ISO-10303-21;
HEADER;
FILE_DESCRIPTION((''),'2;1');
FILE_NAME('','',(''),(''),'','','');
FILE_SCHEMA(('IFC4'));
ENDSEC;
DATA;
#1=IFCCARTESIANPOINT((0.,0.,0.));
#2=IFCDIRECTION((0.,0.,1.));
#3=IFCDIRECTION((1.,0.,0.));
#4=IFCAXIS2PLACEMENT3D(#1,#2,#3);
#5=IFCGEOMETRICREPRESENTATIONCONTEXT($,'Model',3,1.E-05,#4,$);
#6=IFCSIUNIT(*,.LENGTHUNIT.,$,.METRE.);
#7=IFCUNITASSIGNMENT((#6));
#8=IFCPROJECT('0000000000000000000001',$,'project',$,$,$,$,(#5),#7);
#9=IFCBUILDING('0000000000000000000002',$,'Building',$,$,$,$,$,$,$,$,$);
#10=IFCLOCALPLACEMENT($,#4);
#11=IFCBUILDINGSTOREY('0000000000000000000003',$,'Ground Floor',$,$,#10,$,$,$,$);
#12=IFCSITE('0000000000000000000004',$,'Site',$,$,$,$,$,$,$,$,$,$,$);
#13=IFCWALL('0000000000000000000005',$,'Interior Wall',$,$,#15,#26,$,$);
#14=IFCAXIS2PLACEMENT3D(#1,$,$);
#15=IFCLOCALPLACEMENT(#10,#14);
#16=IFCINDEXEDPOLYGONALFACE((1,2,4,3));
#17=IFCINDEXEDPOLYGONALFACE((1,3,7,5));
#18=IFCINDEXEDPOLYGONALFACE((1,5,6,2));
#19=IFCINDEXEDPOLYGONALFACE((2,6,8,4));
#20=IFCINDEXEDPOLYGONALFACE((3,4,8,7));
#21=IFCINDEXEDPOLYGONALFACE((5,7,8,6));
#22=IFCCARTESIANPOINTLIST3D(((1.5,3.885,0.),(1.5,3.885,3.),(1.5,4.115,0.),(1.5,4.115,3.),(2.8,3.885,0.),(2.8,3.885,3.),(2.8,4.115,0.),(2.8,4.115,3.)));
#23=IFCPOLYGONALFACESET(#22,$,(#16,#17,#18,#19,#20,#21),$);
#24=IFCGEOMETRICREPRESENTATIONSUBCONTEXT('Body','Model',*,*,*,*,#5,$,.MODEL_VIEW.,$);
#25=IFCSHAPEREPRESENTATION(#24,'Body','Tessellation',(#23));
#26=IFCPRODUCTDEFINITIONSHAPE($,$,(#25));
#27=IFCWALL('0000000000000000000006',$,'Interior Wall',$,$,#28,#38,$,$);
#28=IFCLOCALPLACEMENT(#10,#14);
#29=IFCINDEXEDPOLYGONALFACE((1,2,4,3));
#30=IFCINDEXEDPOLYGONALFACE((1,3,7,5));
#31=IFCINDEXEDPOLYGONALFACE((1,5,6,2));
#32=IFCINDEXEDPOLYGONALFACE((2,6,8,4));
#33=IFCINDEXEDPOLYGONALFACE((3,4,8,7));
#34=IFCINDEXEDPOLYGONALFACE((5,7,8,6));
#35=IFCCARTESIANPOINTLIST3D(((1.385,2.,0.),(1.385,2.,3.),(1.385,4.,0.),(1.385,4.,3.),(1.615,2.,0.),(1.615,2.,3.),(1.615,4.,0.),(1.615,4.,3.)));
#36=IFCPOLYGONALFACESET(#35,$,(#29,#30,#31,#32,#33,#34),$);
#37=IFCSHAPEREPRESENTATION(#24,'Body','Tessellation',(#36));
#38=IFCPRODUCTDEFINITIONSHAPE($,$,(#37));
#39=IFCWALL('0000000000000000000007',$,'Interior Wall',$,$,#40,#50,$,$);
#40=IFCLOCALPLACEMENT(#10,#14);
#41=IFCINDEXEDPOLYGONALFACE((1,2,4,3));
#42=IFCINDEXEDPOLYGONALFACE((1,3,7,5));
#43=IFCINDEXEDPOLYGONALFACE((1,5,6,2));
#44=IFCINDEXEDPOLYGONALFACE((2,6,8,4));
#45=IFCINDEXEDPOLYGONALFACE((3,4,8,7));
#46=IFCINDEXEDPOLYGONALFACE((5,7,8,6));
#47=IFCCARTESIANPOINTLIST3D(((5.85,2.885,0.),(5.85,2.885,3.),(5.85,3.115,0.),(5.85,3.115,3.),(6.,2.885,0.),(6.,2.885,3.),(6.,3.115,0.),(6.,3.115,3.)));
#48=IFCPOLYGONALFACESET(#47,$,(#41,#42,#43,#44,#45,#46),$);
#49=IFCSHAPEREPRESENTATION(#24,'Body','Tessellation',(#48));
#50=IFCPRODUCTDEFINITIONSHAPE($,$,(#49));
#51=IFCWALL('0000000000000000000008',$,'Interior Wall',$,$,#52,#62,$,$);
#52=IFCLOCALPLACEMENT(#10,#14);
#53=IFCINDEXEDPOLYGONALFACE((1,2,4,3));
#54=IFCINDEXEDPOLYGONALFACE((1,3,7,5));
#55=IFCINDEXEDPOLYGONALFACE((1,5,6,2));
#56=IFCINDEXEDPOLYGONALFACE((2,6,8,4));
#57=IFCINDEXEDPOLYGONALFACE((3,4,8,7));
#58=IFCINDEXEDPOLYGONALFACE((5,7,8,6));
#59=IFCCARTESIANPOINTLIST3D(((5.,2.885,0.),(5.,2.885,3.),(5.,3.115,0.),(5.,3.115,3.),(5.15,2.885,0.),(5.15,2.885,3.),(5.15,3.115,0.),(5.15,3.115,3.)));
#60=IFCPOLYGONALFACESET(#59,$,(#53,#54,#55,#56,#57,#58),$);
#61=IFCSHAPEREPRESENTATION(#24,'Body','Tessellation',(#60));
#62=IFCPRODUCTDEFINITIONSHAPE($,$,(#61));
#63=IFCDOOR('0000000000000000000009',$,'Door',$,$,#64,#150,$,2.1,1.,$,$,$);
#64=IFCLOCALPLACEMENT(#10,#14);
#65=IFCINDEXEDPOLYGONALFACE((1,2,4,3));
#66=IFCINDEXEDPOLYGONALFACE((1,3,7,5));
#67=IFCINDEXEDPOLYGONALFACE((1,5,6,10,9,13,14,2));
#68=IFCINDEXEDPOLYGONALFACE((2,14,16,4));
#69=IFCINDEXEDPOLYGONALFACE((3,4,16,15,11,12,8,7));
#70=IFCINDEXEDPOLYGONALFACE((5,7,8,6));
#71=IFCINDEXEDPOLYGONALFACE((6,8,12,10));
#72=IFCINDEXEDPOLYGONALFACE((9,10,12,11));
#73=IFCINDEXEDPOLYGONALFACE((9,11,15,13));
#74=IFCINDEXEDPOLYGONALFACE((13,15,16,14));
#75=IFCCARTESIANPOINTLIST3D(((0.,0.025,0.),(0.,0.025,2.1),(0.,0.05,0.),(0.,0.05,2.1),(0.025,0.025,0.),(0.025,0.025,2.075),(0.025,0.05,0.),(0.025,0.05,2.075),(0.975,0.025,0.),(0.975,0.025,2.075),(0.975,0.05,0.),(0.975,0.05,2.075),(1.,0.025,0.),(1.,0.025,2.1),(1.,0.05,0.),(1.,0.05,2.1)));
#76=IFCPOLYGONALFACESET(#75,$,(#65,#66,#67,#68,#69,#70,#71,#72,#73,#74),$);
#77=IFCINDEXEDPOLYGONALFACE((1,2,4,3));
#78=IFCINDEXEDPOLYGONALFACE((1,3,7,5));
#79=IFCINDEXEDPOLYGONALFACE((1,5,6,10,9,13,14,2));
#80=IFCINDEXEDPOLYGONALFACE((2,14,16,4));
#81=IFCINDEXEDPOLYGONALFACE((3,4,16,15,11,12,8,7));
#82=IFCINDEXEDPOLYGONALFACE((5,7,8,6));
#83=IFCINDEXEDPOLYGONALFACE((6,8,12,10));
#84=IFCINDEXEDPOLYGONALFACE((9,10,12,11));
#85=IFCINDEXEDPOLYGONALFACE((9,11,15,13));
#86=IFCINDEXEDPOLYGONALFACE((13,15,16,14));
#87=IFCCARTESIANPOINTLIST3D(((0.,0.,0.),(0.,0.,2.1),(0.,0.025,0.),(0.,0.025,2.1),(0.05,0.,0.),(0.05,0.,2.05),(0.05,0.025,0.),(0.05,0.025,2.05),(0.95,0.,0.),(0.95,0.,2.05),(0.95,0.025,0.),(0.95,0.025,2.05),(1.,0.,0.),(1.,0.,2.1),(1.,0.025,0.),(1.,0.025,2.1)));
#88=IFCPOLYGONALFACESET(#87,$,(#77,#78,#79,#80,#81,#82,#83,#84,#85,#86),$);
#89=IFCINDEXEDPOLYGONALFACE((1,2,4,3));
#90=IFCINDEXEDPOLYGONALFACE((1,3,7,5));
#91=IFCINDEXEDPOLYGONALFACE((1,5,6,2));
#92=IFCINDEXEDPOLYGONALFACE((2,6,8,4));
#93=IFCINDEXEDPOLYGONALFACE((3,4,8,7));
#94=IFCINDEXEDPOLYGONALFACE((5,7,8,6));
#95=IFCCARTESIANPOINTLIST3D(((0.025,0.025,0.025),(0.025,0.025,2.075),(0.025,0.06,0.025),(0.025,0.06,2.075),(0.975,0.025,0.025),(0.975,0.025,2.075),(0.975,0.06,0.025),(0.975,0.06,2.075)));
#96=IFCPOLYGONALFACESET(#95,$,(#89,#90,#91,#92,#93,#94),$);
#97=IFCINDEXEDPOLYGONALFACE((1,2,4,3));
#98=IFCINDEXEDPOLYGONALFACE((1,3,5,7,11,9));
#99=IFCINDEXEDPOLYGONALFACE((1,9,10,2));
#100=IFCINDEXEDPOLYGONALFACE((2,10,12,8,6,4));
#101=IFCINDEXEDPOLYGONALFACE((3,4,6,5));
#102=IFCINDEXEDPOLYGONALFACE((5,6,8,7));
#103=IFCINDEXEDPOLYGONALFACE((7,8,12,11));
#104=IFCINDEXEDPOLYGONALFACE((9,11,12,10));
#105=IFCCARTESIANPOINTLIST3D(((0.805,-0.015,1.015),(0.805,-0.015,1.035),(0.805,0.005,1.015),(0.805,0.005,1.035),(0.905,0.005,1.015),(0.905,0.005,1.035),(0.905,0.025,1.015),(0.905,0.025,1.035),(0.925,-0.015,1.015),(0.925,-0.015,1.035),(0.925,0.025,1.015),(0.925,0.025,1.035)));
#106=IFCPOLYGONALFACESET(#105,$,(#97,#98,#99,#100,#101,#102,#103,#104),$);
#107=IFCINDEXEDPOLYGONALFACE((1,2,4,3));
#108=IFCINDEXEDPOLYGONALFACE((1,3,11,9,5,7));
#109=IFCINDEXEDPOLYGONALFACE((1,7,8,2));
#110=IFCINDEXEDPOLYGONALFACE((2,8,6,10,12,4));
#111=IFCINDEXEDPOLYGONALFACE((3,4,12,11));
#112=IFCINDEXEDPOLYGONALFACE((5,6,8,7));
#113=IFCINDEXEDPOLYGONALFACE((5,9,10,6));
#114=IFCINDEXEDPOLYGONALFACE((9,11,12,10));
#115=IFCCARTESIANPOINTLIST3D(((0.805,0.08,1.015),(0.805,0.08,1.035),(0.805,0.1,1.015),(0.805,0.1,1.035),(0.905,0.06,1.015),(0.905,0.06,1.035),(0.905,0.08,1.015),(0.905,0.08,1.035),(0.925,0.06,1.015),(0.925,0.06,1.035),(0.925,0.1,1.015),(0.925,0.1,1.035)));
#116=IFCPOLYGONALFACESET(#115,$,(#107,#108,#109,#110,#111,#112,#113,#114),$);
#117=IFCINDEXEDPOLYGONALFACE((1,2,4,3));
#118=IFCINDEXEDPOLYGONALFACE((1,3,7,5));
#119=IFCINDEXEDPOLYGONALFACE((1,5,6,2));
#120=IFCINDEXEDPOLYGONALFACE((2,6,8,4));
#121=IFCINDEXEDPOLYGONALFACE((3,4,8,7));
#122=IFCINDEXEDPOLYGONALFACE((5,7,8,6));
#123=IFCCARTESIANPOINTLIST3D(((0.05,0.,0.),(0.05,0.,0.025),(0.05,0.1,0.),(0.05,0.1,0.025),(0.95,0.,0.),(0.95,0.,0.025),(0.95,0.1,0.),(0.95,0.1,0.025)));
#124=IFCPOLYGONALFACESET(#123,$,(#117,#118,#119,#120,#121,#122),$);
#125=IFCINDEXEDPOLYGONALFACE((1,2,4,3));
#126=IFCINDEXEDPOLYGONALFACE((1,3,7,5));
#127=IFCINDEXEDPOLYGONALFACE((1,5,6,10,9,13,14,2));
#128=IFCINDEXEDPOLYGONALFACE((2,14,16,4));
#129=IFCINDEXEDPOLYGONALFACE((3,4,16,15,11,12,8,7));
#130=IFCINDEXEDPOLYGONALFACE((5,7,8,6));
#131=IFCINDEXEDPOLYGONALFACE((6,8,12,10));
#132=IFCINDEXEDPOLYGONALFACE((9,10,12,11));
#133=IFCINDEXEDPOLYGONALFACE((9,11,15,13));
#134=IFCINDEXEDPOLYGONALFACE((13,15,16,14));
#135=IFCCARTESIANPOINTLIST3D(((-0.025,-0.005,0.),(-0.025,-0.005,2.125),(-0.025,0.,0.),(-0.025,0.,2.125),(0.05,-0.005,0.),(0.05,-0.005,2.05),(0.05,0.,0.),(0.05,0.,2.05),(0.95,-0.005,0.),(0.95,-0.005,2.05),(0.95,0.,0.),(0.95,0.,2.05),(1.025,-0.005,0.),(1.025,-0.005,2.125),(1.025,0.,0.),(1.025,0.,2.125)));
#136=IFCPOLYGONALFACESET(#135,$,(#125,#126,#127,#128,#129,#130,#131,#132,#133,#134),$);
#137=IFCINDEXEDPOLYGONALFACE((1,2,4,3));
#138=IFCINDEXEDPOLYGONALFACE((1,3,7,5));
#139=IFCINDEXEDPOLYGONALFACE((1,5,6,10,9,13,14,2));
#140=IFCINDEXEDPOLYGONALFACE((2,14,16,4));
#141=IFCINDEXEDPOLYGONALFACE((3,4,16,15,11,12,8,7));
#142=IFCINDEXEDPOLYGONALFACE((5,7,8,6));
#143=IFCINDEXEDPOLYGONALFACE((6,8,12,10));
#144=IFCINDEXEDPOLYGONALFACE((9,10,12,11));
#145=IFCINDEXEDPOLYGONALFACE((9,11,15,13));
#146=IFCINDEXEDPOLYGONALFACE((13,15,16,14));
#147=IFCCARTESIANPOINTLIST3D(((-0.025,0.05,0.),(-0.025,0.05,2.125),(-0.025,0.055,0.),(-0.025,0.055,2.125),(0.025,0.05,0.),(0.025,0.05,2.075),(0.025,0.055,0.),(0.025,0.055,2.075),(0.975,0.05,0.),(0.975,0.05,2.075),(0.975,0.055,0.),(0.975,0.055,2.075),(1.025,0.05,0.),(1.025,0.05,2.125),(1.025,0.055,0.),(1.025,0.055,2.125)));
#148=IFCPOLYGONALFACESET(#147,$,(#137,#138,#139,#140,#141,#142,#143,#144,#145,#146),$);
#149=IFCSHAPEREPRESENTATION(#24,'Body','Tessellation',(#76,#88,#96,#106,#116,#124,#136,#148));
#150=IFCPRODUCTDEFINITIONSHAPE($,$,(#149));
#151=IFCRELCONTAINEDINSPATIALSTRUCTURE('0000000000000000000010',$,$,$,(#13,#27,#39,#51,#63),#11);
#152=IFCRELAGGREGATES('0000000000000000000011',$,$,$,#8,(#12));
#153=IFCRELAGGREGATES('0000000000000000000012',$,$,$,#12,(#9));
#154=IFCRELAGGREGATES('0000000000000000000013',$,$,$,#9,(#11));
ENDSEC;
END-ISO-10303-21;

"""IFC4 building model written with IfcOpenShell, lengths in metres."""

from ifc_helpers import new_model, si_unit, frame, origin_with_axes, place, context, subcontext, project, spatial, line, indexed_curve, outline, extrude, element, save


model = new_model("IFC4")

# Units and contexts
model_context = context("Model", 3, precision=1e-05, world=origin_with_axes())
body_context = subcontext(model_context, "Body", "Model", "MODEL_VIEW")
ifc_project = project(units=[si_unit("LENGTHUNIT", "METRE")], contexts=[model_context])

# Site, building, storey
site = spatial("IfcSite", under=ifc_project, Name="Site")
building = spatial("IfcBuilding", under=site, Name="Building")
storey_placement = place(None, origin_with_axes())
storey = spatial("IfcBuildingStorey", under=building, at=storey_placement, Name="Ground Floor")

# Walls
for number, where, z_axis, x_axis, name in (
    (1, (2.8, 4.0, 0.0), (0.0, 0.0, 1.0), (-1.0, 0.0, 0.0), "Interior Wall"),
):
    element("IfcWall", number, at=place(storey_placement, frame(where, z_axis=z_axis, x_axis=x_axis)), inside=storey, Name=name, context=body_context, shape_type="SweptSolid", body=[
        extrude(outline(indexed_curve([(0.0, 0.0), (0.0, 0.23), (1.3, 0.23), (1.3, 0.0), (0.0, 0.0)], self_intersect=False)), frame((0.0, -0.115, 0.0), z_axis=(0.0, 0.0, 1.0), x_axis=(1.0, 0.0, 0.0)), (0.0, 0.0, 1.0), 3.0),
    ])
wall_1_placement = place(storey_placement, frame((1.5, 4.0, 0.0), z_axis=(0.0, 0.0, 1.0), x_axis=(0.0, -1.0, 0.0)))
element("IfcWall", 2, at=wall_1_placement, inside=storey, Name="Interior Wall", context=body_context, shape_type="SweptSolid", body=[
    extrude(outline(indexed_curve([(0.0, 0.0), (0.0, 0.23), (2.0, 0.23), (2.0, 0.0), (0.0, 0.0)], self_intersect=False)), frame((0.0, -0.115, 0.0), z_axis=(0.0, 0.0, 1.0), x_axis=(1.0, 0.0, 0.0)), (0.0, 0.0, 1.0), 3.0),
])
for number, where, z_axis, x_axis, name in (
    (3, (6.0, 3.0, 0.0), (0.0, 0.0, 1.0), (-1.0, 0.0, 0.0), "Interior Wall"),
    (4, (5.15, 3.0, 0.0), (0.0, 0.0, 1.0), (-1.0, 0.0, 0.0), "Interior Wall"),
):
    element("IfcWall", number, at=place(storey_placement, frame(where, z_axis=z_axis, x_axis=x_axis)), inside=storey, Name=name, context=body_context, shape_type="SweptSolid", body=[
        extrude(outline(indexed_curve([(0.0, 0.0), (0.0, 0.23), (0.15, 0.23), (0.15, 0.0), (0.0, 0.0)], self_intersect=False)), frame((0.0, -0.115, 0.0), z_axis=(0.0, 0.0, 1.0), x_axis=(1.0, 0.0, 0.0)), (0.0, 0.0, 1.0), 3.0),
    ])

# Door
door_1_placement = place(storey_placement, origin_with_axes())
element("IfcDoor", 5, at=door_1_placement, inside=storey, Name="Door", OverallHeight=2.1, OverallWidth=1.0, context=body_context, shape_type="SweptSolid", body=[
    extrude(outline(indexed_curve([(0.0, 0.0), (0.0, 2.1), (1.0, 2.1), (1.0, 0.0), (0.975, 0.0), (0.975, 2.075), (0.025, 2.075), (0.025, 0.0)], segments=[line(1, 2, 3, 4, 5, 6, 7, 8, 1)])), frame((0.0, 0.025, 0.0), z_axis=(0.0, -1.0, 0.0), x_axis=(1.0, 0.0, 0.0)), (0.0, 0.0, -1.0), 0.025),
    extrude(outline(indexed_curve([(0.0, 0.0), (0.0, 2.1), (1.0, 2.1), (1.0, 0.0), (0.95, 0.0), (0.95, 2.05), (0.05, 2.05), (0.05, 0.0)], segments=[line(1, 2, 3, 4, 5, 6, 7, 8, 1)])), frame((0.0, 0.0, 0.0), z_axis=(0.0, -1.0, 0.0), x_axis=(1.0, 0.0, 0.0)), (0.0, 0.0, -1.0), 0.025),
    extrude(outline(indexed_curve([(0.0, 0.0), (0.95, 0.0), (0.95, 0.035), (0.0, 0.035)], segments=[line(1, 2, 3, 4, 1)])), frame((0.025, 0.025, 0.025), z_axis=(0.0, 0.0, 1.0), x_axis=(1.0, 0.0, 0.0)), (0.0, 0.0, 1.0), 2.05),
    extrude(outline(indexed_curve([(0.0, 0.0), (0.0, -0.04), (-0.12, -0.04), (-0.12, -0.02), (-0.02, -0.02), (-0.02, 0.0)], segments=[line(1, 2, 3, 4, 5, 6, 1)])), frame((0.925, 0.025, 1.015), z_axis=(0.0, 0.0, 1.0), x_axis=(1.0, 0.0, 0.0)), (0.0, 0.0, 1.0), 0.02),
    extrude(outline(indexed_curve([(0.0, 0.0), (0.0, 0.04), (-0.12, 0.04), (-0.12, 0.02), (-0.02, 0.02), (-0.02, 0.0)], segments=[line(1, 2, 3, 4, 5, 6, 1)])), frame((0.925, 0.06, 1.015), z_axis=(0.0, 0.0, 1.0), x_axis=(1.0, 0.0, 0.0)), (0.0, 0.0, 1.0), 0.02),
    extrude(outline(indexed_curve([(0.0, 0.0), (0.9, 0.0), (0.9, 0.1), (0.0, 0.1)], segments=[line(1, 2, 3, 4, 1)])), frame((0.05, 0.0, 0.0), z_axis=(0.0, 0.0, 1.0), x_axis=(1.0, 0.0, 0.0)), (0.0, 0.0, 1.0), 0.025),
    extrude(outline(indexed_curve([(0.0, 0.0), (0.0, 2.125), (1.05, 2.125), (1.05, 0.0), (0.975, 0.0), (0.975, 2.05), (0.075, 2.05), (0.075, 0.0)], segments=[line(1, 2, 3, 4, 5, 6, 7, 8, 1)])), frame((-0.025, -0.005, 0.0), z_axis=(0.0, -1.0, 0.0), x_axis=(1.0, 0.0, 0.0)), (0.0, 0.0, -1.0), 0.005),
    extrude(outline(indexed_curve([(0.0, 0.0), (0.0, 2.125), (1.05, 2.125), (1.05, 0.0), (1.0, 0.0), (1.0, 2.075), (0.05, 2.075), (0.05, 0.0)], segments=[line(1, 2, 3, 4, 5, 6, 7, 8, 1)])), frame((-0.025, 0.05, 0.0), z_axis=(0.0, -1.0, 0.0), x_axis=(1.0, 0.0, 0.0)), (0.0, 0.0, -1.0), 0.005),
])

save(model, "model.ifc")
